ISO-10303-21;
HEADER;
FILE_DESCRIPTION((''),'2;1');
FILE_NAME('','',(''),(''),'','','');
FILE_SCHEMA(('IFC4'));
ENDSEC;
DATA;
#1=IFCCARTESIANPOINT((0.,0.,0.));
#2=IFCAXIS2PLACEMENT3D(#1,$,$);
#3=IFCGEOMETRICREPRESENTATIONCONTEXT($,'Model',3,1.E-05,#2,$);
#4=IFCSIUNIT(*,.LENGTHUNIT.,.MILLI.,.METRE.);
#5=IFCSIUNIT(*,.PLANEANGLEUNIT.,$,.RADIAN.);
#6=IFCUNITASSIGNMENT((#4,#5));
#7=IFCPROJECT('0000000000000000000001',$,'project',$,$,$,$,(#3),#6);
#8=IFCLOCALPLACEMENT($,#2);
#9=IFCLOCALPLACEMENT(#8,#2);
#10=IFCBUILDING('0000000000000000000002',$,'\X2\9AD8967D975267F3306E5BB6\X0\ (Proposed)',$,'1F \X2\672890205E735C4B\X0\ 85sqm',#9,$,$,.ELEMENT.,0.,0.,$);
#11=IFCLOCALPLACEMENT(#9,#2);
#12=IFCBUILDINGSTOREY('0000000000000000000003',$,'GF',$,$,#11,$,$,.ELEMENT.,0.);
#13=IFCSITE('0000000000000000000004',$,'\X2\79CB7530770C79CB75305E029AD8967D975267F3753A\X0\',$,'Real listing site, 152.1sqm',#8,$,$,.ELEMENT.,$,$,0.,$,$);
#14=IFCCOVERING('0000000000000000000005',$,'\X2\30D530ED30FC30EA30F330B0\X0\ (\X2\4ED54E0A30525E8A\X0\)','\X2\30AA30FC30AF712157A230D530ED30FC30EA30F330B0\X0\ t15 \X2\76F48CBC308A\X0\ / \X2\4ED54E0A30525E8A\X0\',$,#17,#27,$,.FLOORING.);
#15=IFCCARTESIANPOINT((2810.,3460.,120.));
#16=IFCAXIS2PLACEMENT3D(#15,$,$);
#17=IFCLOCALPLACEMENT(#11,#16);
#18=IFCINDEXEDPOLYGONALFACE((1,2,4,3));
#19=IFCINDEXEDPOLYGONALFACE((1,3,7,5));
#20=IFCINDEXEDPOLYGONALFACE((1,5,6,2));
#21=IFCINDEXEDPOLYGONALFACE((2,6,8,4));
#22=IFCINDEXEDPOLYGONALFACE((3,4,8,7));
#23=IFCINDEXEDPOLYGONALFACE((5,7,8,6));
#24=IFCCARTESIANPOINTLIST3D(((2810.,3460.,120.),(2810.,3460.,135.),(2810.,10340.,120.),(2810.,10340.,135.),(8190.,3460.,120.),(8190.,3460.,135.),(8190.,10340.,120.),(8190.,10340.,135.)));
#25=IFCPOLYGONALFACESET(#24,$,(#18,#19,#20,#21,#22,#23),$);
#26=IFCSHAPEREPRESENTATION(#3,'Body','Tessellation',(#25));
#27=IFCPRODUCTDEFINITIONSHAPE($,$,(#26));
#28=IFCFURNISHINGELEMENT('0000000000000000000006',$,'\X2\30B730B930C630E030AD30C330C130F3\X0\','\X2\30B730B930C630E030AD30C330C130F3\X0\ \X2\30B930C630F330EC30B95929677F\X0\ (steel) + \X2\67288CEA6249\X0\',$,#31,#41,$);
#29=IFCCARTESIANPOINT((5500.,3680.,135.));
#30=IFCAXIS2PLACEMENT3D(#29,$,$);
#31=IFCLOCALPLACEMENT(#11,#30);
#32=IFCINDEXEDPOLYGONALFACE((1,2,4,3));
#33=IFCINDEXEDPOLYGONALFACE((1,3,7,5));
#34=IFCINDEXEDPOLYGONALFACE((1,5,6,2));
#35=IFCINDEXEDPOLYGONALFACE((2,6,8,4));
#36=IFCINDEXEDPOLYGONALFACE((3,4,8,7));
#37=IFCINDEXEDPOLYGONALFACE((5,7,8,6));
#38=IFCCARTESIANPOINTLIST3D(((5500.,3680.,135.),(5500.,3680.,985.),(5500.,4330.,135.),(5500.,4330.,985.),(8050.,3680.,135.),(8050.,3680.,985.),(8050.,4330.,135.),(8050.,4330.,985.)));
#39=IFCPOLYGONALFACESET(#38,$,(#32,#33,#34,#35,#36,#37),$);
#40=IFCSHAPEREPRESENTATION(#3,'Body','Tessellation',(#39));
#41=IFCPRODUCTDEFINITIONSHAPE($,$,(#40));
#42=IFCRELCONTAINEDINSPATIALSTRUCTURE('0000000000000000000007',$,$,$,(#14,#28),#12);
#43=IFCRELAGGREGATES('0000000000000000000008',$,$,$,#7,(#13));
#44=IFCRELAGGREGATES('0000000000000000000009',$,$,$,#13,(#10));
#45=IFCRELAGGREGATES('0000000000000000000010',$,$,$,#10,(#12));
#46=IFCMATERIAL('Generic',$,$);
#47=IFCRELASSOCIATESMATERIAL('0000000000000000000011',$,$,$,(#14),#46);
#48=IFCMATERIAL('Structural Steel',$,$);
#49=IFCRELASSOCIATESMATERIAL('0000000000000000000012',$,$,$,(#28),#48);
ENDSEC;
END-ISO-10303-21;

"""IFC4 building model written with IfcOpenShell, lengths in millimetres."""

from ifc_helpers import new_model, si_unit, frame, frame_2d, origin, place, context, project, spatial, rectangle, extrude, material, element, save


model = new_model("IFC4")

# Units and contexts
model_context = context("Model", 3, precision=1e-05, world=origin())
ifc_project = project(units=[si_unit("LENGTHUNIT", "METRE", prefix="MILLI"), si_unit("PLANEANGLEUNIT", "RADIAN")], contexts=[model_context])

# Site, building, storey
site_placement = place(None, origin())
site = spatial("IfcSite", under=ifc_project, at=site_placement, Name="秋田県秋田市高陽青柳町", ObjectType="Real listing site, 152.1sqm", CompositionType="ELEMENT", RefElevation=0.0)
building_placement = place(site_placement, origin())
building = spatial("IfcBuilding", under=site, at=building_placement, Name="高陽青柳の家 (Proposed)", ObjectType="1F 木造平屋 85sqm", CompositionType="ELEMENT", ElevationOfRefHeight=0.0, ElevationOfTerrain=0.0)
storey_placement = place(building_placement, origin())
storey = spatial("IfcBuildingStorey", under=building, at=storey_placement, Name="GF", CompositionType="ELEMENT", Elevation=0.0)

# Shared definitions
ifc_material_1 = material(Name="Generic")

# Covering
covering_placement = place(storey_placement, frame((2810.0, 3460.0, 120.0)))
element("IfcCovering", 1, at=covering_placement, inside=storey, material=ifc_material_1, Name="フローリング (仕上げ床)", Description="オーク無垢フローリング t15 直貼り / 仕上げ床", PredefinedType="FLOORING", context=model_context, shape_type="SweptSolid", body=[
    extrude(rectangle(XDim=5380.0, YDim=6880.0, at=frame_2d((2690.0, 3440.0))), frame((2810.0, 3460.0, 120.0)), (0.0, 0.0, 1.0), 15.0),
])

# Furnishing element
ifc_material_2 = material(Name="Structural Steel")
furnishing_placement = place(storey_placement, frame((5500.0, 3680.0, 135.0)))
element("IfcFurnishingElement", 2, at=furnishing_placement, inside=storey, material=ifc_material_2, Name="システムキッチン", Description="システムキッチン ステンレス天板 (steel) + 木質扉", context=model_context, shape_type="SweptSolid", body=[
    extrude(rectangle(XDim=2550.0, YDim=650.0, at=frame_2d((1275.0, 325.0))), frame((5500.0, 3680.0, 135.0)), (0.0, 0.0, 1.0), 850.0),
])

save(model, "model.ifc")
